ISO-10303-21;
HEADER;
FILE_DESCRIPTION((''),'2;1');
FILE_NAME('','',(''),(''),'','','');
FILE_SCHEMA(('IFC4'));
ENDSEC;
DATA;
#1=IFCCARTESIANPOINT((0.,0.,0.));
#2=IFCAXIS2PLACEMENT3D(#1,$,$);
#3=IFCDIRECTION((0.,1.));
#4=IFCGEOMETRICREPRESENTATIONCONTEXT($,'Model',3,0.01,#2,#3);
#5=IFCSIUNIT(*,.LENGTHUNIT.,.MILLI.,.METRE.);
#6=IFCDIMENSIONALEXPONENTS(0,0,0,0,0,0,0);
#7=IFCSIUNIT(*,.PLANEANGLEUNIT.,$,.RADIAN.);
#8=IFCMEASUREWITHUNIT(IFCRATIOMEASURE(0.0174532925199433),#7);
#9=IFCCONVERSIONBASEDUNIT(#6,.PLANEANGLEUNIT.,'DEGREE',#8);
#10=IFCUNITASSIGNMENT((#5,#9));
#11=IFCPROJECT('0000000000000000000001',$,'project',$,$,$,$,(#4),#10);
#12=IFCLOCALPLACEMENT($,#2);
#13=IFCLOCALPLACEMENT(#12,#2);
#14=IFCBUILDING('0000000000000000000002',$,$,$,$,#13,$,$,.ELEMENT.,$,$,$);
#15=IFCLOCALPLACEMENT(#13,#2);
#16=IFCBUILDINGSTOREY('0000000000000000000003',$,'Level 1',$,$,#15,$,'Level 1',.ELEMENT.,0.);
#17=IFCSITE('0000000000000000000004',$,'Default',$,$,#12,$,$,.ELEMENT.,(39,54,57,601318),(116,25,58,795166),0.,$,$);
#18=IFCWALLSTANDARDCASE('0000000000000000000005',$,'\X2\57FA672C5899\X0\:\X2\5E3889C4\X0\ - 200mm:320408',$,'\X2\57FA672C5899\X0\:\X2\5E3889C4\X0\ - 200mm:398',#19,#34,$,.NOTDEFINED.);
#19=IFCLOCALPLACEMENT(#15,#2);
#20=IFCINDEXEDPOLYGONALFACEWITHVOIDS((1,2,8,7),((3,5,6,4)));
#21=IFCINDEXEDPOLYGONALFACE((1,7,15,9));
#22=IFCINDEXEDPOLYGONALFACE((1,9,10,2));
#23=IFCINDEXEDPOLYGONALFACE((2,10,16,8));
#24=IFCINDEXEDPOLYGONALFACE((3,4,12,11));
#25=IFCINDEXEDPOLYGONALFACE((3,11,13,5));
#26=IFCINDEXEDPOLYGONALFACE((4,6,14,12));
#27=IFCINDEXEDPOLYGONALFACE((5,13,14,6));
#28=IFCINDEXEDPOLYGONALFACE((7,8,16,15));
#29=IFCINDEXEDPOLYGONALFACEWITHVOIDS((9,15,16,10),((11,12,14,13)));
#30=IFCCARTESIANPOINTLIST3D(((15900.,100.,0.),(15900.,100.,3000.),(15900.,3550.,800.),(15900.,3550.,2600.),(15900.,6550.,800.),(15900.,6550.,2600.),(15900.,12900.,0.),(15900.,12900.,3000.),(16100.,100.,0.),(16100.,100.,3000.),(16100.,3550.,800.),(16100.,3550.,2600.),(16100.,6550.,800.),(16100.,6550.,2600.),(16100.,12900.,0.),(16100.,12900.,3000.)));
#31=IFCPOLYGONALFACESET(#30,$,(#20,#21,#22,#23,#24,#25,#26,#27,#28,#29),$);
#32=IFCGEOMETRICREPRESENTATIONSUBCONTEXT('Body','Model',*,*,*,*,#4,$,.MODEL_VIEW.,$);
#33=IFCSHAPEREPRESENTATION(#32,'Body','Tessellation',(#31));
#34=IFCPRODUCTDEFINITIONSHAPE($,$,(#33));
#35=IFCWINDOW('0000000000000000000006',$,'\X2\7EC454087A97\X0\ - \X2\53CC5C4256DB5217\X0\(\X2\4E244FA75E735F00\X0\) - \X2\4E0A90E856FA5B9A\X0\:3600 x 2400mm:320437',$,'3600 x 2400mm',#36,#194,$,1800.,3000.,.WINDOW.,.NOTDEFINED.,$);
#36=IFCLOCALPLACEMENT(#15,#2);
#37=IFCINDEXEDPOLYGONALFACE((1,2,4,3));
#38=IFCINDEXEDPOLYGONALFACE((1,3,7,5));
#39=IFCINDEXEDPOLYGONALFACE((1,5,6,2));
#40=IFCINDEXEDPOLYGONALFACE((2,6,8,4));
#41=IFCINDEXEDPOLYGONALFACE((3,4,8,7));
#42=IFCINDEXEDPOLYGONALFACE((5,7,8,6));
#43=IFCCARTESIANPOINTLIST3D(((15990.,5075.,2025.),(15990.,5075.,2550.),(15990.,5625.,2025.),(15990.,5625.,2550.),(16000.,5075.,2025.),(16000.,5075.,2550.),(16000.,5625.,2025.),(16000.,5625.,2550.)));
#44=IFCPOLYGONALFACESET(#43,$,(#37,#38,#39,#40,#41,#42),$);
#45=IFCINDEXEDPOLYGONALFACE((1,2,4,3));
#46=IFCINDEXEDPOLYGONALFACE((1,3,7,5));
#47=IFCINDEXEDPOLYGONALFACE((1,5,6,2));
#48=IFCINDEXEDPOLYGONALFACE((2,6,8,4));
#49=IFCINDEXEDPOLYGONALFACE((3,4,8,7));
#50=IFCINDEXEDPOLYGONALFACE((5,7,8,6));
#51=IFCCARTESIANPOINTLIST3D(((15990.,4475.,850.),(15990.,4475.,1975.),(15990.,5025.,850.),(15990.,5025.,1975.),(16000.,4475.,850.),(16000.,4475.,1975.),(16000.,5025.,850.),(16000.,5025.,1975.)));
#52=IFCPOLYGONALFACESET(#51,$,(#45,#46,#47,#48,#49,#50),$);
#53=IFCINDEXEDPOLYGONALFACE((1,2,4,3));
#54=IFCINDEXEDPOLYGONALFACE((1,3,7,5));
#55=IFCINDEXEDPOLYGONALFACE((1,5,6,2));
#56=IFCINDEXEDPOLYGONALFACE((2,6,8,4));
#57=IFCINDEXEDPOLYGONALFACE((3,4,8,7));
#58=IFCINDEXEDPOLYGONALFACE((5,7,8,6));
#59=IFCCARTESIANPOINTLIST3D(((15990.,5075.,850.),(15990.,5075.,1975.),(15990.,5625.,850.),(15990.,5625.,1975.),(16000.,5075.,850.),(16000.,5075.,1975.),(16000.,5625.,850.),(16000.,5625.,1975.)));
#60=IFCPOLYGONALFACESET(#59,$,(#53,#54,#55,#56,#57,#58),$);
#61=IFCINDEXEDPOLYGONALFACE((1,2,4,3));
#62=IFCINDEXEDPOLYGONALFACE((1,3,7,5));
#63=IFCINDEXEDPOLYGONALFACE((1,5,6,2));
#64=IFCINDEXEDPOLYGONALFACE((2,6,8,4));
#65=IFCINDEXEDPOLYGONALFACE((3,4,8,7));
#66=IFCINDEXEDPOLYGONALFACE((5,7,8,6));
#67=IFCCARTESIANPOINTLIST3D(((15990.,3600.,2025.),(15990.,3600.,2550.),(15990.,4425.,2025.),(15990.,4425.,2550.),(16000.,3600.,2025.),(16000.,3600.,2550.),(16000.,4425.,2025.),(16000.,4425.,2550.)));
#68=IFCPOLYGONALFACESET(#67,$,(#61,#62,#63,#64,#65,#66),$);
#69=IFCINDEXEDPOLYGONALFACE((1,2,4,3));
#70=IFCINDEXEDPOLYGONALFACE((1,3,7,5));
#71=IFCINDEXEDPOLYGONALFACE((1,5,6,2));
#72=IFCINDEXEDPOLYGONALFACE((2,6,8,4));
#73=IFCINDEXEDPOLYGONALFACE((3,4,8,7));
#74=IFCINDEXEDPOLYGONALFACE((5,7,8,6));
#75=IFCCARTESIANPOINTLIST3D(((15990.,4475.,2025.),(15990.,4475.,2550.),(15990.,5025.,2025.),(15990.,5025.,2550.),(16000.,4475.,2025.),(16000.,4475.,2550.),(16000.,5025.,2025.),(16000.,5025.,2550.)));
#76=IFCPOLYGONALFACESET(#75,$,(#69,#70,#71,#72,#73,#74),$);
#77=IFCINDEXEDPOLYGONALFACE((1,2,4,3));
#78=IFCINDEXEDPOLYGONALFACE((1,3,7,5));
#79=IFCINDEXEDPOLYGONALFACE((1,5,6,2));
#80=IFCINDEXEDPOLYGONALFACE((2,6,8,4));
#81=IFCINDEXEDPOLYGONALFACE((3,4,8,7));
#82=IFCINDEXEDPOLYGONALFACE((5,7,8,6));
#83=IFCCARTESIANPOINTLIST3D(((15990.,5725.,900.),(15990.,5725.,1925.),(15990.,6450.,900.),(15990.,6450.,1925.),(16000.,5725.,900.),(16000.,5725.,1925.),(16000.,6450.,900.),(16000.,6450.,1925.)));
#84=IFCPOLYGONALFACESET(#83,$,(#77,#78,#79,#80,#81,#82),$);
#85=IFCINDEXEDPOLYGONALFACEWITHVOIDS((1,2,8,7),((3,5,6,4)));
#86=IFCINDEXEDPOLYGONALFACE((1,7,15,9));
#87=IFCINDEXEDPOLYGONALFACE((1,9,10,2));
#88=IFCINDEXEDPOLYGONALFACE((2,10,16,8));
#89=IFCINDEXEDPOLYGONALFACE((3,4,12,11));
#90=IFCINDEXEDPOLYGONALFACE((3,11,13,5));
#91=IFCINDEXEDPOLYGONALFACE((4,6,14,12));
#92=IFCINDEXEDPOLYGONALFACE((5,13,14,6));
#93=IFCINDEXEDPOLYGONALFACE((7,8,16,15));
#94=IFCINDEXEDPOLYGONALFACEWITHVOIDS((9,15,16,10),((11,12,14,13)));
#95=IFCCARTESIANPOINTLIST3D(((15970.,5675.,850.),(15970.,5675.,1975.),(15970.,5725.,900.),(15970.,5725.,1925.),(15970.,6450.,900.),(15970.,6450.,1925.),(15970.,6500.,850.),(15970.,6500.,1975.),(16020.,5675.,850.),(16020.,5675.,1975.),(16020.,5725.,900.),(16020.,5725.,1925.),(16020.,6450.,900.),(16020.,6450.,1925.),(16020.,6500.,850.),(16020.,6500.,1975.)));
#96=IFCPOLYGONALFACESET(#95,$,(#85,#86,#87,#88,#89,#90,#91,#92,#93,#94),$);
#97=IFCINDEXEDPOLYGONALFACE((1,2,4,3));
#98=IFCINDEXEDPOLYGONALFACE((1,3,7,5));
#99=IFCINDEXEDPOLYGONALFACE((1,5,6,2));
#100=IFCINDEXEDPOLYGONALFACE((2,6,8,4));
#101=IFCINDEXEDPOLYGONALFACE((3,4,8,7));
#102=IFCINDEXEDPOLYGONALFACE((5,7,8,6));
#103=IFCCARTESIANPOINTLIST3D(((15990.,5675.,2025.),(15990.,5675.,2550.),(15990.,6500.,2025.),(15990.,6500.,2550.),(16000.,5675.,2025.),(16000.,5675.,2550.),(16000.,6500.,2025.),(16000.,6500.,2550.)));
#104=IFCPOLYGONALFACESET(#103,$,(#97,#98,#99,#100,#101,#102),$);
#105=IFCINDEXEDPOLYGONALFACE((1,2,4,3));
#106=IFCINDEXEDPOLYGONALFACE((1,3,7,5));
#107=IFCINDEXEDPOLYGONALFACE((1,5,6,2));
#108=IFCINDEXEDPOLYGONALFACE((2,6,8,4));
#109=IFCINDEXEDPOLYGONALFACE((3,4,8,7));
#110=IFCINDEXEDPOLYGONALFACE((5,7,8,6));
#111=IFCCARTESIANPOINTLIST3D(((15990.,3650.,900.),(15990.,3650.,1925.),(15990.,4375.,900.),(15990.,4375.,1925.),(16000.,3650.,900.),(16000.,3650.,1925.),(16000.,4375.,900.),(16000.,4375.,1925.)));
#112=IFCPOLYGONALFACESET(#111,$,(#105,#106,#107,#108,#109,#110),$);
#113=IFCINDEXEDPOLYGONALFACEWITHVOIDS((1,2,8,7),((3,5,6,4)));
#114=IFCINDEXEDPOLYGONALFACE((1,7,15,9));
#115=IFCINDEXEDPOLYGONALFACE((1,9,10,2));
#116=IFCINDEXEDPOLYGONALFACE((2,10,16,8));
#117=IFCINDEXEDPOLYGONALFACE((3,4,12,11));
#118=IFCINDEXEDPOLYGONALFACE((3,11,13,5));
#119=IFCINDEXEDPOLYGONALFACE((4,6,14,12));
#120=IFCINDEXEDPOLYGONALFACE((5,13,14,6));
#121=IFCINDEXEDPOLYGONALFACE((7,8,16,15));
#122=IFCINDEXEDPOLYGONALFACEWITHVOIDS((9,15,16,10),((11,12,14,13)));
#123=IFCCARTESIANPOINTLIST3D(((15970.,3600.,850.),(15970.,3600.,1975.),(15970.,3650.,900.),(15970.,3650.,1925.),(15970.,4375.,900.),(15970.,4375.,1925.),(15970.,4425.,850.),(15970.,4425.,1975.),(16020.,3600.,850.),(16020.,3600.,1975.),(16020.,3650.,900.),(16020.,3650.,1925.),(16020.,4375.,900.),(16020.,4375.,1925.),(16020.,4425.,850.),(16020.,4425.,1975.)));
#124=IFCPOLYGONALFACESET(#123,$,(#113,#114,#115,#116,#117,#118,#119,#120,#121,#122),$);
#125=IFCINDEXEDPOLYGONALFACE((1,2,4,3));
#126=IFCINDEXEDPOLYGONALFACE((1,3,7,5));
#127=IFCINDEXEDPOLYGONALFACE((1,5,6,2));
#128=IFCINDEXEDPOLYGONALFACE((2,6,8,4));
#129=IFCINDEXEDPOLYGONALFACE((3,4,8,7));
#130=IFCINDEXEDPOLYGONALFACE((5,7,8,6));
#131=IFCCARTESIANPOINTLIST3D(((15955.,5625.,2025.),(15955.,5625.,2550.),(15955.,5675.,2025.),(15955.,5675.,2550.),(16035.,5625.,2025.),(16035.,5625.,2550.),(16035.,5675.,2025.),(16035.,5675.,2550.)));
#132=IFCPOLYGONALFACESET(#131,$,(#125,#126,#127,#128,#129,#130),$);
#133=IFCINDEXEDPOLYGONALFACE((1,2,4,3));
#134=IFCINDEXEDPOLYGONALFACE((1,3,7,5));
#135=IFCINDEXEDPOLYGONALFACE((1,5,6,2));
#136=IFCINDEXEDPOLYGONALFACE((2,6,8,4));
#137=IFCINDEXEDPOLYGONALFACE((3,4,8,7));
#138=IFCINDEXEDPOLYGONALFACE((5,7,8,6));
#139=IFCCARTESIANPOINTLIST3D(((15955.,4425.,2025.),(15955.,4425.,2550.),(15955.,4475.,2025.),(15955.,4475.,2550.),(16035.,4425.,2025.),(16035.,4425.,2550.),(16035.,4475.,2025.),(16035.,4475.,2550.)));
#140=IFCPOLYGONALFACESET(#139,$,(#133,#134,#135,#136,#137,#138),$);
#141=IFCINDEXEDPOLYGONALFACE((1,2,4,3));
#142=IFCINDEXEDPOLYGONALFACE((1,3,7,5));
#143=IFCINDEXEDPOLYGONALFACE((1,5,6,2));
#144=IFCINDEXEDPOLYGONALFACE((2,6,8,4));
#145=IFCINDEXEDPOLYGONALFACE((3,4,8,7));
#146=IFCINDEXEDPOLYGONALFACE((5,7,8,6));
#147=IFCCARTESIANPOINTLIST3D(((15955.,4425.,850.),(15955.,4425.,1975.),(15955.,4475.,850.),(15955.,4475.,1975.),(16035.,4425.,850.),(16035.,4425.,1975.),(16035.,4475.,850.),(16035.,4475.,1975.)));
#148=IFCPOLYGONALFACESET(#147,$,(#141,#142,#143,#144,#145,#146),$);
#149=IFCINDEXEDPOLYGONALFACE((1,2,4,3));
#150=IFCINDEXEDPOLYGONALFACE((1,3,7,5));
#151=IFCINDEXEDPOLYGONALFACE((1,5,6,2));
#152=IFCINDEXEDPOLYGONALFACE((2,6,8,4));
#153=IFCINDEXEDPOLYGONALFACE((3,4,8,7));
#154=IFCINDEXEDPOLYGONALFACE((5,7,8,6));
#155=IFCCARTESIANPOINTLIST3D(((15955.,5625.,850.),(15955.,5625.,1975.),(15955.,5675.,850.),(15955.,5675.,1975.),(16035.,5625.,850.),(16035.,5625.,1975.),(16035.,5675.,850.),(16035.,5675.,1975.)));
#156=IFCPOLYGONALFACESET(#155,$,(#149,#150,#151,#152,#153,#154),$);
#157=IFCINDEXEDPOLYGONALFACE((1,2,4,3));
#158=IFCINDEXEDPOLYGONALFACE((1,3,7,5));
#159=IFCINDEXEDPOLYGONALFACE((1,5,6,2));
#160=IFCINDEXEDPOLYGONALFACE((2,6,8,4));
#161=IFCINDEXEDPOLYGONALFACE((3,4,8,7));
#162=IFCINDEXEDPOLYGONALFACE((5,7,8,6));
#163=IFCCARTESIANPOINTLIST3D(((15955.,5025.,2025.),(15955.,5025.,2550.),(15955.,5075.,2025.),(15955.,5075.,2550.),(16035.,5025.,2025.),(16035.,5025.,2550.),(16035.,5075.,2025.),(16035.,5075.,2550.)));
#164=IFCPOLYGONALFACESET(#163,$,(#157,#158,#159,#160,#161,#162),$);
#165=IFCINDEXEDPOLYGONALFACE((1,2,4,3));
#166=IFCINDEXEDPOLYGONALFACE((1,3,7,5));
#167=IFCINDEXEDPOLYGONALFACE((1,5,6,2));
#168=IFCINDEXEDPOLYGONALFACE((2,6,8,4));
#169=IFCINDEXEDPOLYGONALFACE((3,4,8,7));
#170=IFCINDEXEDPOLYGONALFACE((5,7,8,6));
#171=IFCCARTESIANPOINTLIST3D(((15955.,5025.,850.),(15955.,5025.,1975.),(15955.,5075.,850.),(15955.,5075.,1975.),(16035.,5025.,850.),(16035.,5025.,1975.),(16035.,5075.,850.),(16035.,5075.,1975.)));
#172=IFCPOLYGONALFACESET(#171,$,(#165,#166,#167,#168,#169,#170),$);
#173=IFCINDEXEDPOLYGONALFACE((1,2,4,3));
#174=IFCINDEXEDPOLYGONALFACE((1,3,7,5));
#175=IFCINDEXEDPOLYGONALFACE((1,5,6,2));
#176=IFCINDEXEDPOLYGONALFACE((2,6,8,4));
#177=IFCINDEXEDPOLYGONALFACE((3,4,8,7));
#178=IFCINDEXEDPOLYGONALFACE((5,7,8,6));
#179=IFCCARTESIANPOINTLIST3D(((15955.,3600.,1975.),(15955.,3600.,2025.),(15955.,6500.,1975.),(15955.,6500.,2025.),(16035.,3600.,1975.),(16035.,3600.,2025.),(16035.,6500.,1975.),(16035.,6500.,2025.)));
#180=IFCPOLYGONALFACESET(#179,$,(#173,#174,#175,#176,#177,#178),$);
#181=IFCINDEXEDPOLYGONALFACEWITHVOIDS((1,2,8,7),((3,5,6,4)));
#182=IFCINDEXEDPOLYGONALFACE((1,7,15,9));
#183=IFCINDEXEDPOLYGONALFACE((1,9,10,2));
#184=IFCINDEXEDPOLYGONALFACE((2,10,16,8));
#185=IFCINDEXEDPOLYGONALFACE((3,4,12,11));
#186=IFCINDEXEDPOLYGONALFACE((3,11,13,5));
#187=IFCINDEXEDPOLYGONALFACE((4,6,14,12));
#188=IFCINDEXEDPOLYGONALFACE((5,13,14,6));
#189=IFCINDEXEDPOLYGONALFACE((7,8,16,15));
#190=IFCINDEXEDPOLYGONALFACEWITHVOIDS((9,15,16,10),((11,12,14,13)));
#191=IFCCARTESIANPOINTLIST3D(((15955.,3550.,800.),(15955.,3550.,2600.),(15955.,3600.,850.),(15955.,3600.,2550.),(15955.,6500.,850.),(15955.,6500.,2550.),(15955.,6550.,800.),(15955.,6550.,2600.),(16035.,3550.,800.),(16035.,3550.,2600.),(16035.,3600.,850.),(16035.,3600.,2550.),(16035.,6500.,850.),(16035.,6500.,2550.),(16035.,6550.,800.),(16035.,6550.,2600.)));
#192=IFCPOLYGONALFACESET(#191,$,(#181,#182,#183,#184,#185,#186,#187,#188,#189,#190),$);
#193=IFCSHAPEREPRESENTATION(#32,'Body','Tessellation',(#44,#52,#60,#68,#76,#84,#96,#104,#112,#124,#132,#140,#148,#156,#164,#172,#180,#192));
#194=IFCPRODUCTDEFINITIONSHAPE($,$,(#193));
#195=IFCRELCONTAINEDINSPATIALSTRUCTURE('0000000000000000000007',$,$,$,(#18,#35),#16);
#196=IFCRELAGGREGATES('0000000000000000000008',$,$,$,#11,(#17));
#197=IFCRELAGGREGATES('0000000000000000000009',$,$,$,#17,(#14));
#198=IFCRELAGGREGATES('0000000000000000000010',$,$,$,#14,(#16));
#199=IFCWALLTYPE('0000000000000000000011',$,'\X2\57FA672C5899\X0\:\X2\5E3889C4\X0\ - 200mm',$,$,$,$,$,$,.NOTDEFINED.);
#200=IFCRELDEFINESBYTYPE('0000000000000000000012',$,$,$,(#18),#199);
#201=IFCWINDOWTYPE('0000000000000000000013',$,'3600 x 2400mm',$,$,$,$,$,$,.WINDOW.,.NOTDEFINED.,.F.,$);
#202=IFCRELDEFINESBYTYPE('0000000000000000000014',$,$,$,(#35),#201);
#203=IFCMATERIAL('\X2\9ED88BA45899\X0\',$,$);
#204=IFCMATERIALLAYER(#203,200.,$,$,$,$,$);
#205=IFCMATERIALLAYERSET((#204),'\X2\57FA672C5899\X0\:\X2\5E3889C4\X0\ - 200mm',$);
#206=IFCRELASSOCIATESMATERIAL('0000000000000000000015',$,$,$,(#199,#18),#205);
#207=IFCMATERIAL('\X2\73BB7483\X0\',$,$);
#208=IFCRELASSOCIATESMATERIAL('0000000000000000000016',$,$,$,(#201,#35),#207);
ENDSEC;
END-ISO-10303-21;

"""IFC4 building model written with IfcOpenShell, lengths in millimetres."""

from ifc_helpers import new_model, entity, si_unit, converted_unit, direction, frame, frame_2d, origin, origin_2d_with_axis, place, context, subcontext, project, spatial, polyline, rectangle, outline, extrude, source, transform, mapped, material, layer, layer_set, layer_usage, type_object, type_shapes, element, fill, save


model = new_model("IFC4")

# Units and contexts
model_context = context("Model", 3, precision=0.01, world=origin(), true_north=direction((0.0, 1.0)))
body_context = subcontext(model_context, "Body", "Model", "MODEL_VIEW")
ifc_project = project(units=[si_unit("LENGTHUNIT", "METRE", prefix="MILLI"), converted_unit("PLANEANGLEUNIT", "DEGREE", entity("IfcRatioMeasure", 0.0174532925199433), si_unit("PLANEANGLEUNIT", "RADIAN"), dimensions=[0, 0, 0, 0, 0, 0, 0])], contexts=[model_context])

# Site, building, storey
site_placement = place(None, origin())
site = spatial("IfcSite", under=ifc_project, at=site_placement, Name="Default", CompositionType="ELEMENT", RefLatitude=(39, 54, 57, 601318), RefLongitude=(116, 25, 58, 795166), RefElevation=0.0)
building_placement = place(site_placement, origin())
building = spatial("IfcBuilding", under=site, at=building_placement, CompositionType="ELEMENT")
storey_placement = place(building_placement, origin())
storey = spatial("IfcBuildingStorey", under=building, at=storey_placement, Name="Level 1", LongName="Level 1", CompositionType="ELEMENT", Elevation=0.0)

# Shared definitions
ifc_material_1 = material(Name="默认墙")
ifc_layer = layer(ifc_material_1, 200.0)
ifc_layer_set = layer_set([ifc_layer], Name="基本墙:常规 - 200mm")
wall_type = type_object("IfcWallType", Name="基本墙:常规 - 200mm", PredefinedType="NOTDEFINED", material=ifc_layer_set)
ifc_material_2 = material(Name="玻璃")
window_type = type_object("IfcWindowType", Name="3600 x 2400mm", ParameterTakesPrecedence=False, PartitioningType="NOTDEFINED", PredefinedType="WINDOW", material=ifc_material_2)
shared_shape_1 = source(origin(), body_context, "Body", "SweptSolid", [
    extrude(rectangle(XDim=10.0, YDim=550.0, at=origin_2d_with_axis()), frame((1200.0, 95.0, 1225.0), z_axis=(0.0, 0.0, 1.0), x_axis=(0.0, 1.0, 0.0)), (0.0, 0.0, 1.0), 525.0),
    extrude(rectangle(XDim=10.0, YDim=550.0, at=origin_2d_with_axis()), frame((1800.0, 95.0, 50.0), z_axis=(0.0, 0.0, 1.0), x_axis=(0.0, 1.0, 0.0)), (0.0, 0.0, 1.0), 1125.0),
    extrude(rectangle(XDim=10.0, YDim=550.0, at=origin_2d_with_axis()), frame((1200.0, 95.0, 50.0), z_axis=(0.0, 0.0, 1.0), x_axis=(0.0, 1.0, 0.0)), (0.0, 0.0, 1.0), 1125.0),
    extrude(rectangle(XDim=10.0, YDim=825.0, at=frame_2d((0.0, 0.0), x_axis=(1.0, 0.0))), frame((2537.5, 95.0, 1225.0), z_axis=(0.0, 0.0, 1.0), x_axis=(0.0, 1.0, 0.0)), (0.0, 0.0, 1.0), 525.0),
    extrude(rectangle(XDim=10.0, YDim=550.0, at=frame_2d((0.0, 0.0), x_axis=(1.0, 0.0))), frame((1800.0, 95.0, 1225.0), z_axis=(0.0, 0.0, 1.0), x_axis=(0.0, 1.0, 0.0)), (0.0, 0.0, 1.0), 525.0),
    extrude(rectangle(XDim=10.0, YDim=725.0, at=frame_2d((0.0, 0.0), x_axis=(1.0, 0.0))), frame((462.5, 95.0, 100.0), z_axis=(0.0, 0.0, 1.0), x_axis=(0.0, 1.0, 0.0)), (0.0, 0.0, 1.0), 1025.0),
    extrude(outline(polyline([(-562.5, -412.5), (562.5, -412.5), (562.5, 412.5), (-562.5, 412.5), (-562.5, -412.5)]), holes=[polyline([(512.5, -362.5), (-512.5, -362.5), (-512.5, 362.5), (512.5, 362.5), (512.5, -362.5)])]), frame((462.5, 70.0, 612.5), z_axis=(0.0, 1.0, 0.0), x_axis=(0.0, 0.0, -1.0)), (0.0, 0.0, 1.0), 50.0),
    extrude(rectangle(XDim=10.0, YDim=825.0, at=origin_2d_with_axis()), frame((462.5, 95.0, 1225.0), z_axis=(0.0, 0.0, 1.0), x_axis=(0.0, 1.0, 0.0)), (0.0, 0.0, 1.0), 525.0),
    extrude(rectangle(XDim=10.0, YDim=725.0, at=frame_2d((0.0, 0.0), x_axis=(1.0, 0.0))), frame((2537.5, 95.0, 100.0), z_axis=(0.0, 0.0, 1.0), x_axis=(0.0, 1.0, 0.0)), (0.0, 0.0, 1.0), 1025.0),
    extrude(outline(polyline([(-562.5, -412.5), (562.5, -412.5), (562.5, 412.5), (-562.5, 412.5), (-562.5, -412.5)]), holes=[polyline([(512.5, -362.5), (-512.5, -362.5), (-512.5, 362.5), (512.5, 362.5), (512.5, -362.5)])]), frame((2537.5, 70.0, 612.5), z_axis=(0.0, 1.0, 0.0), x_axis=(0.0, 0.0, -1.0)), (0.0, 0.0, 1.0), 50.0),
    extrude(rectangle(XDim=80.0, YDim=50.0, at=origin_2d_with_axis()), frame((900.0, 95.0, 1225.0), z_axis=(0.0, 0.0, 1.0), x_axis=(0.0, -1.0, 0.0)), (0.0, 0.0, 1.0), 525.0),
    extrude(rectangle(XDim=80.0, YDim=50.0, at=frame_2d((0.0, 0.0), x_axis=(1.0, 0.0))), frame((2100.0, 95.0, 1225.0), z_axis=(0.0, 0.0, 1.0), x_axis=(0.0, -1.0, 0.0)), (0.0, 0.0, 1.0), 525.0),
    extrude(rectangle(XDim=80.0, YDim=50.0, at=origin_2d_with_axis()), frame((2100.0, 95.0, 50.0), z_axis=(0.0, 0.0, 1.0), x_axis=(0.0, -1.0, 0.0)), (0.0, 0.0, 1.0), 1125.0),
    extrude(rectangle(XDim=80.0, YDim=50.0, at=origin_2d_with_axis()), frame((900.0, 95.0, 50.0), z_axis=(0.0, 0.0, 1.0), x_axis=(0.0, -1.0, 0.0)), (0.0, 0.0, 1.0), 1125.0),
    extrude(rectangle(XDim=80.0, YDim=50.0, at=frame_2d((0.0, 0.0), x_axis=(1.0, 0.0))), frame((1500.0, 95.0, 1225.0), z_axis=(0.0, 0.0, 1.0), x_axis=(0.0, -1.0, 0.0)), (0.0, 0.0, 1.0), 525.0),
    extrude(rectangle(XDim=80.0, YDim=50.0, at=origin_2d_with_axis()), frame((1500.0, 95.0, 50.0), z_axis=(0.0, 0.0, 1.0), x_axis=(0.0, -1.0, 0.0)), (0.0, 0.0, 1.0), 1125.0),
    extrude(rectangle(XDim=80.0, YDim=2900.0, at=frame_2d((0.0, 0.0), x_axis=(1.0, 0.0))), frame((1500.0, 95.0, 1175.0), z_axis=(0.0, 0.0, 1.0), x_axis=(0.0, -1.0, 0.0)), (0.0, 0.0, 1.0), 50.0),
    extrude(outline(polyline([(-1500.0, -900.0), (1500.0, -900.0), (1500.0, 900.0), (-1500.0, 900.0), (-1500.0, -900.0)]), holes=[polyline([(1450.0, -850.0), (-1450.0, -850.0), (-1450.0, 850.0), (1450.0, 850.0), (1450.0, -850.0)])]), frame((1500.0, 55.0, 900.0), z_axis=(0.0, 1.0, 0.0), x_axis=(1.0, 0.0, 0.0)), (0.0, 0.0, 1.0), 80.0),
])
type_shapes(window_type, [shared_shape_1])

# Wall, opening, window
ifc_layer_usage_1 = layer_usage(ifc_layer_set, "AXIS2", "NEGATIVE", 100.0)
wall_1_placement = place(storey_placement, frame((16000.0, 12900.0, 0.0), z_axis=(0.0, 0.0, 1.0), x_axis=(0.0, -1.0, 0.0)))
wall_1 = element("IfcWallStandardCase", 1, at=wall_1_placement, inside=storey, type_object=wall_type, material=ifc_layer_usage_1, Name="基本墙:常规 - 200mm:320408", ObjectType="基本墙:常规 - 200mm:398", PredefinedType="NOTDEFINED", context=body_context, shape_type="SweptSolid", body=[
    extrude(rectangle(XDim=12800.0, YDim=200.0, at=frame_2d((6400.0, 0.0), x_axis=(-1.0, 0.0))), origin(), (0.0, 0.0, 1.0), 3000.0),
])
opening_1_placement = place(wall_1_placement, frame((6350.0, -100.0, 800.0)))
opening_1 = element("IfcOpeningElement", 2, at=opening_1_placement, cuts=wall_1, ObjectType="Opening", PredefinedType="OPENING", context=body_context, shape_type="SweptSolid", body=[
    extrude(rectangle(XDim=1800.0, YDim=3000.0, at=frame_2d((900.0, 1500.0), x_axis=(1.0, 0.0))), frame((0.0, 0.0, 0.0), z_axis=(0.0, 1.0, 0.0), x_axis=(0.0, 0.0, 1.0)), (0.0, 0.0, 1.0), 200.0),
])
window_1_placement = place(opening_1_placement, origin())
window_1 = element("IfcWindow", 3, at=window_1_placement, inside=storey, type_object=window_type, material=ifc_material_2, Name="组合窗 - 双层四列(两侧平开) - 上部固定:3600 x 2400mm:320437", ObjectType="3600 x 2400mm", OverallHeight=1800.0, OverallWidth=3000.0, PartitioningType="NOTDEFINED", PredefinedType="WINDOW", context=body_context, shape_type="MappedRepresentation", body=[
    mapped(shared_shape_1, transform((0.0, 0.0, 0.0), scale=1.0)),
])
fill(opening_1, window_1)

save(model, "model.ifc")
